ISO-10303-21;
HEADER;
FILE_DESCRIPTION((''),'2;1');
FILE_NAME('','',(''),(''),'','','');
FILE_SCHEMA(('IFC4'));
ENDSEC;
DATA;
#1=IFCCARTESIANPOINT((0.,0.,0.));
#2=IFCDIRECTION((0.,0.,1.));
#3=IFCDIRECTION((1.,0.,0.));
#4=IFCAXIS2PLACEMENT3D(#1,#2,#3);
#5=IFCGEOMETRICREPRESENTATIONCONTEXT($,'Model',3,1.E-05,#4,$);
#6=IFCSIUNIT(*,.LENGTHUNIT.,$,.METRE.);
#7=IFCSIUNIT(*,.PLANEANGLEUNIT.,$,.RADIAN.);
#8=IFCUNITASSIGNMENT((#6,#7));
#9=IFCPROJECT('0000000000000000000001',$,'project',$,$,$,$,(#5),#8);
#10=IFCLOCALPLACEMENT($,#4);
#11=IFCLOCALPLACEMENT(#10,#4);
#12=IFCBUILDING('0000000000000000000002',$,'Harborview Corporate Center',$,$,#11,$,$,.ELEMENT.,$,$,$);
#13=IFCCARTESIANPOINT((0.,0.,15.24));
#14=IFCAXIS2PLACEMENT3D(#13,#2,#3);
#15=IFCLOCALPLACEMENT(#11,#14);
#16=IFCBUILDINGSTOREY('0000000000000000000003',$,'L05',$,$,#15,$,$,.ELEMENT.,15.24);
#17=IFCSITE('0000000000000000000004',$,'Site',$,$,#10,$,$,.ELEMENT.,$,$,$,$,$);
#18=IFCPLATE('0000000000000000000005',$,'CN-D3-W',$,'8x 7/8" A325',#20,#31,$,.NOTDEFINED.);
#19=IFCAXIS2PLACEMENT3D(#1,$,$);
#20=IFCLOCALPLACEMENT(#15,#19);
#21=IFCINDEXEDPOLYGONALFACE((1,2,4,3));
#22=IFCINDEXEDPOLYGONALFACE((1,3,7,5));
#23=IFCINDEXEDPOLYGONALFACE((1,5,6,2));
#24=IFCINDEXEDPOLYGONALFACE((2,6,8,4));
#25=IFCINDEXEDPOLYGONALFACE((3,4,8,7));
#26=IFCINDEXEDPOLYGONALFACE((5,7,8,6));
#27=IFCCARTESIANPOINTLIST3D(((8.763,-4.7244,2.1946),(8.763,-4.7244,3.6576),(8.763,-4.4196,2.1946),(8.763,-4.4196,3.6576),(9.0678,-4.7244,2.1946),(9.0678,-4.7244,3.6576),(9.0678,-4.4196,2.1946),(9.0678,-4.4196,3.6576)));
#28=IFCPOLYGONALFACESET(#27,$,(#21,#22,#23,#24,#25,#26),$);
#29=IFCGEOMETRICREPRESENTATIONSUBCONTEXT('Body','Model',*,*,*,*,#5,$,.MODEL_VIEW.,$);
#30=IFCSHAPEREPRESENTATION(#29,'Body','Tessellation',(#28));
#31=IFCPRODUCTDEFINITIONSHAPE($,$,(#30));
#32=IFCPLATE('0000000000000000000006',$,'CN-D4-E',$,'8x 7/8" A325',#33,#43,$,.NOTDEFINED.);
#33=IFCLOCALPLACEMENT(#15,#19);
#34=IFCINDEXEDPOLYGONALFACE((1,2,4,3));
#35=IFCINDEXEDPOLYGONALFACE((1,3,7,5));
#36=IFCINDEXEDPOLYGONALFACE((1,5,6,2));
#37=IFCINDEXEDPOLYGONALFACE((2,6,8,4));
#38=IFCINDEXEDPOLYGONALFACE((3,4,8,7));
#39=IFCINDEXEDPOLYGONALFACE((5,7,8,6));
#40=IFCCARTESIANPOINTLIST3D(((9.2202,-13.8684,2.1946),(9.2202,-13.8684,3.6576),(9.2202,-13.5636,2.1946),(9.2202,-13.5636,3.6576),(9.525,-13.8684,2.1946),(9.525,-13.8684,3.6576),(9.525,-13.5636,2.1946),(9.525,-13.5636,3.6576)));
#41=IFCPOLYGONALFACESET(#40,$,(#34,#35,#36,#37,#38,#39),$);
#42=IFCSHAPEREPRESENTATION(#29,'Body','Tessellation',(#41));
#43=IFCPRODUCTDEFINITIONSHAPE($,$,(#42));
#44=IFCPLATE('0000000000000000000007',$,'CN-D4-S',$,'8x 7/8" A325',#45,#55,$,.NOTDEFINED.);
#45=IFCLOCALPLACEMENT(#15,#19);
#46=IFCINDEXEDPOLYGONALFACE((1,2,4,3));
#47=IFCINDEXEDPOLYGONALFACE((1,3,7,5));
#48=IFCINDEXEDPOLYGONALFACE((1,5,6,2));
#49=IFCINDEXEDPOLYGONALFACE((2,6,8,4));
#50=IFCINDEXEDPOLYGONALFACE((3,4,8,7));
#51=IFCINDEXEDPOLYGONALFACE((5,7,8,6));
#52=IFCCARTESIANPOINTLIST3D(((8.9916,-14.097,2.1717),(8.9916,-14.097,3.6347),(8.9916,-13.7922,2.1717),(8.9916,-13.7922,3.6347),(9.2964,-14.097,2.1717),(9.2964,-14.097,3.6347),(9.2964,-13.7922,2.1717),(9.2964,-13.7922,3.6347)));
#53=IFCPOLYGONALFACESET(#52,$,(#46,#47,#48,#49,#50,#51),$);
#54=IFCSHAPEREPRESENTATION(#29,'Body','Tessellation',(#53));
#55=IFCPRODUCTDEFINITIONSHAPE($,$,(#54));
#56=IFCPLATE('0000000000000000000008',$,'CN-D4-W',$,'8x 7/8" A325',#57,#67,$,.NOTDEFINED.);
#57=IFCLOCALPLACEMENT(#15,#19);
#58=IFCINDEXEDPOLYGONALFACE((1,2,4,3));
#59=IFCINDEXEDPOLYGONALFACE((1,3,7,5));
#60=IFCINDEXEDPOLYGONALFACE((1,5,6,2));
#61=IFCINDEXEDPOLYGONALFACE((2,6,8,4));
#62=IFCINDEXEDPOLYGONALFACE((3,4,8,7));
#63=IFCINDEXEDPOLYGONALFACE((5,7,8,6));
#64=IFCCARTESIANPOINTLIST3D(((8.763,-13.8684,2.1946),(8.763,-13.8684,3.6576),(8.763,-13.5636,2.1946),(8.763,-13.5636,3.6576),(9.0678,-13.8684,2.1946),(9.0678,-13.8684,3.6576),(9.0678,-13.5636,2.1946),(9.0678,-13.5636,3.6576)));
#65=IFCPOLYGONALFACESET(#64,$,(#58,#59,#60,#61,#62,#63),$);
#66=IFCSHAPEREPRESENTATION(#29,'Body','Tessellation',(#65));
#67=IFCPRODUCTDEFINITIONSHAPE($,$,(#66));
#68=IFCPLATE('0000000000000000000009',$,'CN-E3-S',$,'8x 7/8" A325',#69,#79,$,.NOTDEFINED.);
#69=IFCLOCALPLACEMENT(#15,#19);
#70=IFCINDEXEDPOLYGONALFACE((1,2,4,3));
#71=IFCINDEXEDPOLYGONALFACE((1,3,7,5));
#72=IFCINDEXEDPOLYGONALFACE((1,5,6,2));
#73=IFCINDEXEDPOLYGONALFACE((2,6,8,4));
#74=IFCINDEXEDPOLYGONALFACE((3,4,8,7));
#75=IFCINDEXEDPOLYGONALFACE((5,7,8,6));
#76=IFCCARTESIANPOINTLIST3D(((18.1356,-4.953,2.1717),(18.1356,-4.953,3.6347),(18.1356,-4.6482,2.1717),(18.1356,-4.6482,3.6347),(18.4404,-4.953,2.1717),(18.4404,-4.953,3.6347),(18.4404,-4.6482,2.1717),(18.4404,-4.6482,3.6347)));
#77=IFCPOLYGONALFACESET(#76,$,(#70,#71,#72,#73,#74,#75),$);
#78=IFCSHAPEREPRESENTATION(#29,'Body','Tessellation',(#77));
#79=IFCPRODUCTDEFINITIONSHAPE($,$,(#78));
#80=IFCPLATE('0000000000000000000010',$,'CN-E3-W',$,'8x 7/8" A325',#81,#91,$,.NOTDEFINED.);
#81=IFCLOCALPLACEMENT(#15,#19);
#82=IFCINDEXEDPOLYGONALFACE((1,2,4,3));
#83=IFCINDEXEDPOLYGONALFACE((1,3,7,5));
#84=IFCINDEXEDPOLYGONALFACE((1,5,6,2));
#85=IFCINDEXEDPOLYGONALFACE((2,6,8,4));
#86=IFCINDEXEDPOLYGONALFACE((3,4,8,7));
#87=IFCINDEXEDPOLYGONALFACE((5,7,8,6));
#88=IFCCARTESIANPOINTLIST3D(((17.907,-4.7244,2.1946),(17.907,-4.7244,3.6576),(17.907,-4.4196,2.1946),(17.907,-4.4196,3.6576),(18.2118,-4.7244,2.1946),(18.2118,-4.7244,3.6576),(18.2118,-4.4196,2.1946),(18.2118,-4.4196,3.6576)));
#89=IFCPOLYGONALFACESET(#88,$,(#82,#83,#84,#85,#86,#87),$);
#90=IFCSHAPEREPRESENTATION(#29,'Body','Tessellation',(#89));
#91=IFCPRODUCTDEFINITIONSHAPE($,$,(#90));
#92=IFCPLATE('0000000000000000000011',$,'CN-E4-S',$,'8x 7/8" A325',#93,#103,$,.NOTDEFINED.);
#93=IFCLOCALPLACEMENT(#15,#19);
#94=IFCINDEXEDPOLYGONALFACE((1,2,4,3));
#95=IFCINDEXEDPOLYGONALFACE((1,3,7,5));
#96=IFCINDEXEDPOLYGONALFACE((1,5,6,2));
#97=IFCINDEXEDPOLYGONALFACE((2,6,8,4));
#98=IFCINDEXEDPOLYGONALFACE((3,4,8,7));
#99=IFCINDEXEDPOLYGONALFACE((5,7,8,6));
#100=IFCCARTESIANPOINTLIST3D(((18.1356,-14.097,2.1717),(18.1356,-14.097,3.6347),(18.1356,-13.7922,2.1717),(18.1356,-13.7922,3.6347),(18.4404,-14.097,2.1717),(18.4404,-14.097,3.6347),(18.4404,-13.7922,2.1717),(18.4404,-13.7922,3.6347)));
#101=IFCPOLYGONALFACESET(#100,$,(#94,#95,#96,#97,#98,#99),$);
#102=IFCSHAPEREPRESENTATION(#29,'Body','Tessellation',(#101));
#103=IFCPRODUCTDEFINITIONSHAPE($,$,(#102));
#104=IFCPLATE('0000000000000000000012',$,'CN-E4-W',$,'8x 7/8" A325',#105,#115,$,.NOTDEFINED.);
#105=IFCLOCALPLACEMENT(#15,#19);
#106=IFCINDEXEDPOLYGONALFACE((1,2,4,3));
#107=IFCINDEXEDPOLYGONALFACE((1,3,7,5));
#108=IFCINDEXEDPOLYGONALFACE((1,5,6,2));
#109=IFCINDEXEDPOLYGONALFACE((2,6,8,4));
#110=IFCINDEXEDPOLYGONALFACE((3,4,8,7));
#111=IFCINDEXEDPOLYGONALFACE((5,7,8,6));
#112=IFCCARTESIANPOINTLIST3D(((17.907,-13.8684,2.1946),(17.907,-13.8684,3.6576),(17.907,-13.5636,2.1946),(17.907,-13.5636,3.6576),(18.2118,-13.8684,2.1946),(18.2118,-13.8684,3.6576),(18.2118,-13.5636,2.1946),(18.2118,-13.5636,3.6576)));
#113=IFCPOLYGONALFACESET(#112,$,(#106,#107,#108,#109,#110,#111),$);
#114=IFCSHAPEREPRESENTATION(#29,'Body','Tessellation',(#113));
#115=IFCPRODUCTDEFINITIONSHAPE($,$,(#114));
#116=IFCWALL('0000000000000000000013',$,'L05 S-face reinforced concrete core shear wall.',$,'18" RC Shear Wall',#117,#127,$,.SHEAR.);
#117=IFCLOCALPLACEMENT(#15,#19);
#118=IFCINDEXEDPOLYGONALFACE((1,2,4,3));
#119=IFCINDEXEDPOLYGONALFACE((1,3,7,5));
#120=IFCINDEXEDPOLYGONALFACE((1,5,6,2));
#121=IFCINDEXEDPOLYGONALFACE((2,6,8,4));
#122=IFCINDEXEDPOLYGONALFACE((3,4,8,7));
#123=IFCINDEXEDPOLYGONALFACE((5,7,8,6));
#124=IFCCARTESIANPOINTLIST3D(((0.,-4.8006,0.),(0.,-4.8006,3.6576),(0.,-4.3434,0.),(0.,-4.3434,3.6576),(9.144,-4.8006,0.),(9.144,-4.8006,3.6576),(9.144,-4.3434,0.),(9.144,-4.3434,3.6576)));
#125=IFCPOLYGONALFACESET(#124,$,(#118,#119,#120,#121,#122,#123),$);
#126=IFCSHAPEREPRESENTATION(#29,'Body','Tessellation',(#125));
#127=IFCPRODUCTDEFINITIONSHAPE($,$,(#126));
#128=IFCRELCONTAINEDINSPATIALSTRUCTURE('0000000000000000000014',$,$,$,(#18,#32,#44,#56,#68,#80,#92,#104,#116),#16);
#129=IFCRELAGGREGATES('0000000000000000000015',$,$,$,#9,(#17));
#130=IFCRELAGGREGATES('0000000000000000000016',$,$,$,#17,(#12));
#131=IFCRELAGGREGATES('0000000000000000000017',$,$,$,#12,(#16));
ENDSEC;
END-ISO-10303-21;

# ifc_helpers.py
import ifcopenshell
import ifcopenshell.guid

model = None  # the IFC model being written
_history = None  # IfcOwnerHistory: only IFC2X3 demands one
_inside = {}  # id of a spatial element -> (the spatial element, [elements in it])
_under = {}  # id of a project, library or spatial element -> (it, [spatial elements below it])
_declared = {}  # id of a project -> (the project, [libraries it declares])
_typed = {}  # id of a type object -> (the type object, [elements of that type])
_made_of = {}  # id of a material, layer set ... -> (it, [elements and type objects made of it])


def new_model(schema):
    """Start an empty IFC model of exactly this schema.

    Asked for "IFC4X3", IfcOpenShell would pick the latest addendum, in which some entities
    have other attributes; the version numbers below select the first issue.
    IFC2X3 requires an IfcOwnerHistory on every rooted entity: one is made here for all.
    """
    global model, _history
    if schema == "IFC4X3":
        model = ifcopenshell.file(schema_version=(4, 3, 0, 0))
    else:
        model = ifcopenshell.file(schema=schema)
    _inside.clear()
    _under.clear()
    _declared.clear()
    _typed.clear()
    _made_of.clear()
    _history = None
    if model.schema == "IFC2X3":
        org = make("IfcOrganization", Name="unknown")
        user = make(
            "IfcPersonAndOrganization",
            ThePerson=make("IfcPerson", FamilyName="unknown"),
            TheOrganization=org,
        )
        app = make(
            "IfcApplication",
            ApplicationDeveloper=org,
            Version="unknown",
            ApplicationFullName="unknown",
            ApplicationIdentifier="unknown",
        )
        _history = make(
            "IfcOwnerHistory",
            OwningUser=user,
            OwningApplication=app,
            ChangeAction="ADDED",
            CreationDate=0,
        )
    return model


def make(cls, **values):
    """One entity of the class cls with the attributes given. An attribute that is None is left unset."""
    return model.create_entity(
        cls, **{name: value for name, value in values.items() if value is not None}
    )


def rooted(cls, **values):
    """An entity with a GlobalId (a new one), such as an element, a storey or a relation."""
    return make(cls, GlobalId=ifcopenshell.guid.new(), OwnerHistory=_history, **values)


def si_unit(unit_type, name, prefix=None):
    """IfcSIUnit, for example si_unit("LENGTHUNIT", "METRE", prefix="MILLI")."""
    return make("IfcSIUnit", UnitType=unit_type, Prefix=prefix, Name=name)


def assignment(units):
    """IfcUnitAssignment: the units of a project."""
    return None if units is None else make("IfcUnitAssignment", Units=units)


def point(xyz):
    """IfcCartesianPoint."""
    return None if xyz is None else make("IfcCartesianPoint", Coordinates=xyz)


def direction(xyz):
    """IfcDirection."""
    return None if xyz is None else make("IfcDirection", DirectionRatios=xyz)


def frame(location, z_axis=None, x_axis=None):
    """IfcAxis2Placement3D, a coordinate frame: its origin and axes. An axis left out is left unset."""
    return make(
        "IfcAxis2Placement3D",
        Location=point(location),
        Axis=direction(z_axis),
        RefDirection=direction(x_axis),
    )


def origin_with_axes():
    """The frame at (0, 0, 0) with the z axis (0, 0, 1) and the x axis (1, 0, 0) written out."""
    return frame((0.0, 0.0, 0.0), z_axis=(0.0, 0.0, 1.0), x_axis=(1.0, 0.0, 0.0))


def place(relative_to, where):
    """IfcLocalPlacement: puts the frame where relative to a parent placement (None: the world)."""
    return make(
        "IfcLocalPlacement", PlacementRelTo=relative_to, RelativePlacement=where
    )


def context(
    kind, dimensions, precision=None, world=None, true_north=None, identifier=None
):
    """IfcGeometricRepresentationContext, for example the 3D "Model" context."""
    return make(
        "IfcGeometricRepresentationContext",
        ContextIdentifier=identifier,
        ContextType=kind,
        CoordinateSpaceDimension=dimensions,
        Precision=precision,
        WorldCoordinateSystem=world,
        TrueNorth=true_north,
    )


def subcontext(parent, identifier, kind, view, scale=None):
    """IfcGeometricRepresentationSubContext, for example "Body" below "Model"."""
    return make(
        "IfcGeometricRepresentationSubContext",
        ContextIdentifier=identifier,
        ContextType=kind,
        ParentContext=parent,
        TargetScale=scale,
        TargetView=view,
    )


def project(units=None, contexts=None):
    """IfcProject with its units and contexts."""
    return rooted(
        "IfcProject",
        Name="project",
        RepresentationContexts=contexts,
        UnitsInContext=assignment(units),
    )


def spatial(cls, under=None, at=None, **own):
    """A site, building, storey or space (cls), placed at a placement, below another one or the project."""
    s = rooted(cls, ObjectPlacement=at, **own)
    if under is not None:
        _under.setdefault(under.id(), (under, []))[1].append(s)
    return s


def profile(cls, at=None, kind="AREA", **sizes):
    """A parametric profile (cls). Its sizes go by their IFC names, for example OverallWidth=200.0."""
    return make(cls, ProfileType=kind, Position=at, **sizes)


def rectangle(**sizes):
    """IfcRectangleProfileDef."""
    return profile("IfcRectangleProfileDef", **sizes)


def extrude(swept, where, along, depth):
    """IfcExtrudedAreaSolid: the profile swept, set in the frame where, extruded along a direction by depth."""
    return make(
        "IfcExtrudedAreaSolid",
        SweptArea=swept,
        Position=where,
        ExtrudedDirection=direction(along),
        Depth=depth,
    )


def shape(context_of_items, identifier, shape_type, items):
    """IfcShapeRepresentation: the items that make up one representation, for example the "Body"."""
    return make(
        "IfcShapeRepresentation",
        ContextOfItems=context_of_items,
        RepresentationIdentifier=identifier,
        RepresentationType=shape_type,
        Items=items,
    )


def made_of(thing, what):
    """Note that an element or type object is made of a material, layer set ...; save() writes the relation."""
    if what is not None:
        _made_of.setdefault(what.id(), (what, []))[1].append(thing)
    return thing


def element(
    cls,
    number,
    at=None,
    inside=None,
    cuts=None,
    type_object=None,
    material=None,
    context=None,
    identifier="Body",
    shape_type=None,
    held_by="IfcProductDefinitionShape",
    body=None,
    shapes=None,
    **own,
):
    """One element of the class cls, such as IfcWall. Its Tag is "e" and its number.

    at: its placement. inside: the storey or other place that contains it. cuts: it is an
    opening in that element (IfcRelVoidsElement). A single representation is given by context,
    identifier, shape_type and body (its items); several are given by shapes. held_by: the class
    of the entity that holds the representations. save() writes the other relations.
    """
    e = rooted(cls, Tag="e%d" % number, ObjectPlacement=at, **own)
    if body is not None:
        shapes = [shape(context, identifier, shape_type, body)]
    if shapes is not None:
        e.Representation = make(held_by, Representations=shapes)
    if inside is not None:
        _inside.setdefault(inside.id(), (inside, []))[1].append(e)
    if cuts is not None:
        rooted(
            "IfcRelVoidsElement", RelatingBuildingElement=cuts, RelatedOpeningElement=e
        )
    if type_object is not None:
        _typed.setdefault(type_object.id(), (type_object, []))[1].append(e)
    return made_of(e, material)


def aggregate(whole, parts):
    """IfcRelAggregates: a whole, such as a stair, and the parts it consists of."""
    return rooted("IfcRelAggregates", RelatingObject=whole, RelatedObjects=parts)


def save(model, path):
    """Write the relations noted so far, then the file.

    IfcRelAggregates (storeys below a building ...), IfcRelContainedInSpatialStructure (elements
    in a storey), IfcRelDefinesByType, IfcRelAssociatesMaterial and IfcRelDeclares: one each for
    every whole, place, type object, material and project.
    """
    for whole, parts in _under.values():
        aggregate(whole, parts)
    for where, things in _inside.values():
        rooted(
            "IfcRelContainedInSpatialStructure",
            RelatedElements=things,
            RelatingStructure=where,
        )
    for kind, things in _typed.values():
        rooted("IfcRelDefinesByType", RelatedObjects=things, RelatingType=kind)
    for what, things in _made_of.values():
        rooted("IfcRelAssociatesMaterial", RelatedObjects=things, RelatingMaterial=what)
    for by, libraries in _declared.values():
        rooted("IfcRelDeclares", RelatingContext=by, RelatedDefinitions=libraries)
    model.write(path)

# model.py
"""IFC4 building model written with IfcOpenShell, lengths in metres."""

from ifc_helpers import new_model, si_unit, frame, origin_with_axes, place, context, subcontext, project, spatial, rectangle, extrude, element, save


model = new_model("IFC4")

# Units and contexts
model_context = context("Model", 3, precision=1e-05, world=origin_with_axes())
body_context = subcontext(model_context, "Body", "Model", "MODEL_VIEW")
ifc_project = project(units=[si_unit("LENGTHUNIT", "METRE"), si_unit("PLANEANGLEUNIT", "RADIAN")], contexts=[model_context])

# Site, building, storey
site_placement = place(None, origin_with_axes())
site = spatial("IfcSite", under=ifc_project, at=site_placement, Name="Site", CompositionType="ELEMENT")
building_placement = place(site_placement, origin_with_axes())
building = spatial("IfcBuilding", under=site, at=building_placement, Name="Harborview Corporate Center", CompositionType="ELEMENT")
storey_placement = place(building_placement, frame((0.0, 0.0, 15.24), z_axis=(0.0, 0.0, 1.0), x_axis=(1.0, 0.0, 0.0)))
storey = spatial("IfcBuildingStorey", under=building, at=storey_placement, Name="L05", CompositionType="ELEMENT", Elevation=15.24)

# Plates
for number, where, z_axis, x_axis, name in (
    (1, (8.9154, -4.572, 2.1946), (0.0, 0.0, 1.0), (1.0, 0.0, 0.0), "CN-D3-W"),
    (2, (9.3726, -13.716, 2.1946), (0.0, 0.0, 1.0), (1.0, 0.0, 0.0), "CN-D4-E"),
    (3, (9.144, -13.9446, 2.1717), (0.0, 0.0, 1.0), (1.0, 0.0, 0.0), "CN-D4-S"),
    (4, (8.9154, -13.716, 2.1946), (0.0, 0.0, 1.0), (1.0, 0.0, 0.0), "CN-D4-W"),
    (5, (18.288, -4.8006, 2.1717), (0.0, 0.0, 1.0), (1.0, 0.0, 0.0), "CN-E3-S"),
    (6, (18.0594, -4.572, 2.1946), (0.0, 0.0, 1.0), (1.0, 0.0, 0.0), "CN-E3-W"),
    (7, (18.288, -13.9446, 2.1717), (0.0, 0.0, 1.0), (1.0, 0.0, 0.0), "CN-E4-S"),
    (8, (18.0594, -13.716, 2.1946), (0.0, 0.0, 1.0), (1.0, 0.0, 0.0), "CN-E4-W"),
):
    element("IfcPlate", number, at=place(storey_placement, frame(where, z_axis=z_axis, x_axis=x_axis)), inside=storey, Name=name, ObjectType="8x 7/8\" A325", PredefinedType="NOTDEFINED", context=body_context, shape_type="SweptSolid", body=[
        extrude(rectangle(XDim=0.3048, YDim=0.3048), origin_with_axes(), (0.0, 0.0, 1.0), 1.463),
    ])

# Wall
wall_placement = place(storey_placement, frame((4.572, -4.572, 0.0), z_axis=(0.0, 0.0, 1.0), x_axis=(1.0, 0.0, 0.0)))
element("IfcWall", 9, at=wall_placement, inside=storey, Name="L05 S-face reinforced concrete core shear wall.", ObjectType="18\" RC Shear Wall", PredefinedType="SHEAR", context=body_context, shape_type="SweptSolid", body=[
    extrude(rectangle(XDim=9.144, YDim=0.4572), origin_with_axes(), (0.0, 0.0, 1.0), 3.6576),
])

save(model, "model.ifc")
